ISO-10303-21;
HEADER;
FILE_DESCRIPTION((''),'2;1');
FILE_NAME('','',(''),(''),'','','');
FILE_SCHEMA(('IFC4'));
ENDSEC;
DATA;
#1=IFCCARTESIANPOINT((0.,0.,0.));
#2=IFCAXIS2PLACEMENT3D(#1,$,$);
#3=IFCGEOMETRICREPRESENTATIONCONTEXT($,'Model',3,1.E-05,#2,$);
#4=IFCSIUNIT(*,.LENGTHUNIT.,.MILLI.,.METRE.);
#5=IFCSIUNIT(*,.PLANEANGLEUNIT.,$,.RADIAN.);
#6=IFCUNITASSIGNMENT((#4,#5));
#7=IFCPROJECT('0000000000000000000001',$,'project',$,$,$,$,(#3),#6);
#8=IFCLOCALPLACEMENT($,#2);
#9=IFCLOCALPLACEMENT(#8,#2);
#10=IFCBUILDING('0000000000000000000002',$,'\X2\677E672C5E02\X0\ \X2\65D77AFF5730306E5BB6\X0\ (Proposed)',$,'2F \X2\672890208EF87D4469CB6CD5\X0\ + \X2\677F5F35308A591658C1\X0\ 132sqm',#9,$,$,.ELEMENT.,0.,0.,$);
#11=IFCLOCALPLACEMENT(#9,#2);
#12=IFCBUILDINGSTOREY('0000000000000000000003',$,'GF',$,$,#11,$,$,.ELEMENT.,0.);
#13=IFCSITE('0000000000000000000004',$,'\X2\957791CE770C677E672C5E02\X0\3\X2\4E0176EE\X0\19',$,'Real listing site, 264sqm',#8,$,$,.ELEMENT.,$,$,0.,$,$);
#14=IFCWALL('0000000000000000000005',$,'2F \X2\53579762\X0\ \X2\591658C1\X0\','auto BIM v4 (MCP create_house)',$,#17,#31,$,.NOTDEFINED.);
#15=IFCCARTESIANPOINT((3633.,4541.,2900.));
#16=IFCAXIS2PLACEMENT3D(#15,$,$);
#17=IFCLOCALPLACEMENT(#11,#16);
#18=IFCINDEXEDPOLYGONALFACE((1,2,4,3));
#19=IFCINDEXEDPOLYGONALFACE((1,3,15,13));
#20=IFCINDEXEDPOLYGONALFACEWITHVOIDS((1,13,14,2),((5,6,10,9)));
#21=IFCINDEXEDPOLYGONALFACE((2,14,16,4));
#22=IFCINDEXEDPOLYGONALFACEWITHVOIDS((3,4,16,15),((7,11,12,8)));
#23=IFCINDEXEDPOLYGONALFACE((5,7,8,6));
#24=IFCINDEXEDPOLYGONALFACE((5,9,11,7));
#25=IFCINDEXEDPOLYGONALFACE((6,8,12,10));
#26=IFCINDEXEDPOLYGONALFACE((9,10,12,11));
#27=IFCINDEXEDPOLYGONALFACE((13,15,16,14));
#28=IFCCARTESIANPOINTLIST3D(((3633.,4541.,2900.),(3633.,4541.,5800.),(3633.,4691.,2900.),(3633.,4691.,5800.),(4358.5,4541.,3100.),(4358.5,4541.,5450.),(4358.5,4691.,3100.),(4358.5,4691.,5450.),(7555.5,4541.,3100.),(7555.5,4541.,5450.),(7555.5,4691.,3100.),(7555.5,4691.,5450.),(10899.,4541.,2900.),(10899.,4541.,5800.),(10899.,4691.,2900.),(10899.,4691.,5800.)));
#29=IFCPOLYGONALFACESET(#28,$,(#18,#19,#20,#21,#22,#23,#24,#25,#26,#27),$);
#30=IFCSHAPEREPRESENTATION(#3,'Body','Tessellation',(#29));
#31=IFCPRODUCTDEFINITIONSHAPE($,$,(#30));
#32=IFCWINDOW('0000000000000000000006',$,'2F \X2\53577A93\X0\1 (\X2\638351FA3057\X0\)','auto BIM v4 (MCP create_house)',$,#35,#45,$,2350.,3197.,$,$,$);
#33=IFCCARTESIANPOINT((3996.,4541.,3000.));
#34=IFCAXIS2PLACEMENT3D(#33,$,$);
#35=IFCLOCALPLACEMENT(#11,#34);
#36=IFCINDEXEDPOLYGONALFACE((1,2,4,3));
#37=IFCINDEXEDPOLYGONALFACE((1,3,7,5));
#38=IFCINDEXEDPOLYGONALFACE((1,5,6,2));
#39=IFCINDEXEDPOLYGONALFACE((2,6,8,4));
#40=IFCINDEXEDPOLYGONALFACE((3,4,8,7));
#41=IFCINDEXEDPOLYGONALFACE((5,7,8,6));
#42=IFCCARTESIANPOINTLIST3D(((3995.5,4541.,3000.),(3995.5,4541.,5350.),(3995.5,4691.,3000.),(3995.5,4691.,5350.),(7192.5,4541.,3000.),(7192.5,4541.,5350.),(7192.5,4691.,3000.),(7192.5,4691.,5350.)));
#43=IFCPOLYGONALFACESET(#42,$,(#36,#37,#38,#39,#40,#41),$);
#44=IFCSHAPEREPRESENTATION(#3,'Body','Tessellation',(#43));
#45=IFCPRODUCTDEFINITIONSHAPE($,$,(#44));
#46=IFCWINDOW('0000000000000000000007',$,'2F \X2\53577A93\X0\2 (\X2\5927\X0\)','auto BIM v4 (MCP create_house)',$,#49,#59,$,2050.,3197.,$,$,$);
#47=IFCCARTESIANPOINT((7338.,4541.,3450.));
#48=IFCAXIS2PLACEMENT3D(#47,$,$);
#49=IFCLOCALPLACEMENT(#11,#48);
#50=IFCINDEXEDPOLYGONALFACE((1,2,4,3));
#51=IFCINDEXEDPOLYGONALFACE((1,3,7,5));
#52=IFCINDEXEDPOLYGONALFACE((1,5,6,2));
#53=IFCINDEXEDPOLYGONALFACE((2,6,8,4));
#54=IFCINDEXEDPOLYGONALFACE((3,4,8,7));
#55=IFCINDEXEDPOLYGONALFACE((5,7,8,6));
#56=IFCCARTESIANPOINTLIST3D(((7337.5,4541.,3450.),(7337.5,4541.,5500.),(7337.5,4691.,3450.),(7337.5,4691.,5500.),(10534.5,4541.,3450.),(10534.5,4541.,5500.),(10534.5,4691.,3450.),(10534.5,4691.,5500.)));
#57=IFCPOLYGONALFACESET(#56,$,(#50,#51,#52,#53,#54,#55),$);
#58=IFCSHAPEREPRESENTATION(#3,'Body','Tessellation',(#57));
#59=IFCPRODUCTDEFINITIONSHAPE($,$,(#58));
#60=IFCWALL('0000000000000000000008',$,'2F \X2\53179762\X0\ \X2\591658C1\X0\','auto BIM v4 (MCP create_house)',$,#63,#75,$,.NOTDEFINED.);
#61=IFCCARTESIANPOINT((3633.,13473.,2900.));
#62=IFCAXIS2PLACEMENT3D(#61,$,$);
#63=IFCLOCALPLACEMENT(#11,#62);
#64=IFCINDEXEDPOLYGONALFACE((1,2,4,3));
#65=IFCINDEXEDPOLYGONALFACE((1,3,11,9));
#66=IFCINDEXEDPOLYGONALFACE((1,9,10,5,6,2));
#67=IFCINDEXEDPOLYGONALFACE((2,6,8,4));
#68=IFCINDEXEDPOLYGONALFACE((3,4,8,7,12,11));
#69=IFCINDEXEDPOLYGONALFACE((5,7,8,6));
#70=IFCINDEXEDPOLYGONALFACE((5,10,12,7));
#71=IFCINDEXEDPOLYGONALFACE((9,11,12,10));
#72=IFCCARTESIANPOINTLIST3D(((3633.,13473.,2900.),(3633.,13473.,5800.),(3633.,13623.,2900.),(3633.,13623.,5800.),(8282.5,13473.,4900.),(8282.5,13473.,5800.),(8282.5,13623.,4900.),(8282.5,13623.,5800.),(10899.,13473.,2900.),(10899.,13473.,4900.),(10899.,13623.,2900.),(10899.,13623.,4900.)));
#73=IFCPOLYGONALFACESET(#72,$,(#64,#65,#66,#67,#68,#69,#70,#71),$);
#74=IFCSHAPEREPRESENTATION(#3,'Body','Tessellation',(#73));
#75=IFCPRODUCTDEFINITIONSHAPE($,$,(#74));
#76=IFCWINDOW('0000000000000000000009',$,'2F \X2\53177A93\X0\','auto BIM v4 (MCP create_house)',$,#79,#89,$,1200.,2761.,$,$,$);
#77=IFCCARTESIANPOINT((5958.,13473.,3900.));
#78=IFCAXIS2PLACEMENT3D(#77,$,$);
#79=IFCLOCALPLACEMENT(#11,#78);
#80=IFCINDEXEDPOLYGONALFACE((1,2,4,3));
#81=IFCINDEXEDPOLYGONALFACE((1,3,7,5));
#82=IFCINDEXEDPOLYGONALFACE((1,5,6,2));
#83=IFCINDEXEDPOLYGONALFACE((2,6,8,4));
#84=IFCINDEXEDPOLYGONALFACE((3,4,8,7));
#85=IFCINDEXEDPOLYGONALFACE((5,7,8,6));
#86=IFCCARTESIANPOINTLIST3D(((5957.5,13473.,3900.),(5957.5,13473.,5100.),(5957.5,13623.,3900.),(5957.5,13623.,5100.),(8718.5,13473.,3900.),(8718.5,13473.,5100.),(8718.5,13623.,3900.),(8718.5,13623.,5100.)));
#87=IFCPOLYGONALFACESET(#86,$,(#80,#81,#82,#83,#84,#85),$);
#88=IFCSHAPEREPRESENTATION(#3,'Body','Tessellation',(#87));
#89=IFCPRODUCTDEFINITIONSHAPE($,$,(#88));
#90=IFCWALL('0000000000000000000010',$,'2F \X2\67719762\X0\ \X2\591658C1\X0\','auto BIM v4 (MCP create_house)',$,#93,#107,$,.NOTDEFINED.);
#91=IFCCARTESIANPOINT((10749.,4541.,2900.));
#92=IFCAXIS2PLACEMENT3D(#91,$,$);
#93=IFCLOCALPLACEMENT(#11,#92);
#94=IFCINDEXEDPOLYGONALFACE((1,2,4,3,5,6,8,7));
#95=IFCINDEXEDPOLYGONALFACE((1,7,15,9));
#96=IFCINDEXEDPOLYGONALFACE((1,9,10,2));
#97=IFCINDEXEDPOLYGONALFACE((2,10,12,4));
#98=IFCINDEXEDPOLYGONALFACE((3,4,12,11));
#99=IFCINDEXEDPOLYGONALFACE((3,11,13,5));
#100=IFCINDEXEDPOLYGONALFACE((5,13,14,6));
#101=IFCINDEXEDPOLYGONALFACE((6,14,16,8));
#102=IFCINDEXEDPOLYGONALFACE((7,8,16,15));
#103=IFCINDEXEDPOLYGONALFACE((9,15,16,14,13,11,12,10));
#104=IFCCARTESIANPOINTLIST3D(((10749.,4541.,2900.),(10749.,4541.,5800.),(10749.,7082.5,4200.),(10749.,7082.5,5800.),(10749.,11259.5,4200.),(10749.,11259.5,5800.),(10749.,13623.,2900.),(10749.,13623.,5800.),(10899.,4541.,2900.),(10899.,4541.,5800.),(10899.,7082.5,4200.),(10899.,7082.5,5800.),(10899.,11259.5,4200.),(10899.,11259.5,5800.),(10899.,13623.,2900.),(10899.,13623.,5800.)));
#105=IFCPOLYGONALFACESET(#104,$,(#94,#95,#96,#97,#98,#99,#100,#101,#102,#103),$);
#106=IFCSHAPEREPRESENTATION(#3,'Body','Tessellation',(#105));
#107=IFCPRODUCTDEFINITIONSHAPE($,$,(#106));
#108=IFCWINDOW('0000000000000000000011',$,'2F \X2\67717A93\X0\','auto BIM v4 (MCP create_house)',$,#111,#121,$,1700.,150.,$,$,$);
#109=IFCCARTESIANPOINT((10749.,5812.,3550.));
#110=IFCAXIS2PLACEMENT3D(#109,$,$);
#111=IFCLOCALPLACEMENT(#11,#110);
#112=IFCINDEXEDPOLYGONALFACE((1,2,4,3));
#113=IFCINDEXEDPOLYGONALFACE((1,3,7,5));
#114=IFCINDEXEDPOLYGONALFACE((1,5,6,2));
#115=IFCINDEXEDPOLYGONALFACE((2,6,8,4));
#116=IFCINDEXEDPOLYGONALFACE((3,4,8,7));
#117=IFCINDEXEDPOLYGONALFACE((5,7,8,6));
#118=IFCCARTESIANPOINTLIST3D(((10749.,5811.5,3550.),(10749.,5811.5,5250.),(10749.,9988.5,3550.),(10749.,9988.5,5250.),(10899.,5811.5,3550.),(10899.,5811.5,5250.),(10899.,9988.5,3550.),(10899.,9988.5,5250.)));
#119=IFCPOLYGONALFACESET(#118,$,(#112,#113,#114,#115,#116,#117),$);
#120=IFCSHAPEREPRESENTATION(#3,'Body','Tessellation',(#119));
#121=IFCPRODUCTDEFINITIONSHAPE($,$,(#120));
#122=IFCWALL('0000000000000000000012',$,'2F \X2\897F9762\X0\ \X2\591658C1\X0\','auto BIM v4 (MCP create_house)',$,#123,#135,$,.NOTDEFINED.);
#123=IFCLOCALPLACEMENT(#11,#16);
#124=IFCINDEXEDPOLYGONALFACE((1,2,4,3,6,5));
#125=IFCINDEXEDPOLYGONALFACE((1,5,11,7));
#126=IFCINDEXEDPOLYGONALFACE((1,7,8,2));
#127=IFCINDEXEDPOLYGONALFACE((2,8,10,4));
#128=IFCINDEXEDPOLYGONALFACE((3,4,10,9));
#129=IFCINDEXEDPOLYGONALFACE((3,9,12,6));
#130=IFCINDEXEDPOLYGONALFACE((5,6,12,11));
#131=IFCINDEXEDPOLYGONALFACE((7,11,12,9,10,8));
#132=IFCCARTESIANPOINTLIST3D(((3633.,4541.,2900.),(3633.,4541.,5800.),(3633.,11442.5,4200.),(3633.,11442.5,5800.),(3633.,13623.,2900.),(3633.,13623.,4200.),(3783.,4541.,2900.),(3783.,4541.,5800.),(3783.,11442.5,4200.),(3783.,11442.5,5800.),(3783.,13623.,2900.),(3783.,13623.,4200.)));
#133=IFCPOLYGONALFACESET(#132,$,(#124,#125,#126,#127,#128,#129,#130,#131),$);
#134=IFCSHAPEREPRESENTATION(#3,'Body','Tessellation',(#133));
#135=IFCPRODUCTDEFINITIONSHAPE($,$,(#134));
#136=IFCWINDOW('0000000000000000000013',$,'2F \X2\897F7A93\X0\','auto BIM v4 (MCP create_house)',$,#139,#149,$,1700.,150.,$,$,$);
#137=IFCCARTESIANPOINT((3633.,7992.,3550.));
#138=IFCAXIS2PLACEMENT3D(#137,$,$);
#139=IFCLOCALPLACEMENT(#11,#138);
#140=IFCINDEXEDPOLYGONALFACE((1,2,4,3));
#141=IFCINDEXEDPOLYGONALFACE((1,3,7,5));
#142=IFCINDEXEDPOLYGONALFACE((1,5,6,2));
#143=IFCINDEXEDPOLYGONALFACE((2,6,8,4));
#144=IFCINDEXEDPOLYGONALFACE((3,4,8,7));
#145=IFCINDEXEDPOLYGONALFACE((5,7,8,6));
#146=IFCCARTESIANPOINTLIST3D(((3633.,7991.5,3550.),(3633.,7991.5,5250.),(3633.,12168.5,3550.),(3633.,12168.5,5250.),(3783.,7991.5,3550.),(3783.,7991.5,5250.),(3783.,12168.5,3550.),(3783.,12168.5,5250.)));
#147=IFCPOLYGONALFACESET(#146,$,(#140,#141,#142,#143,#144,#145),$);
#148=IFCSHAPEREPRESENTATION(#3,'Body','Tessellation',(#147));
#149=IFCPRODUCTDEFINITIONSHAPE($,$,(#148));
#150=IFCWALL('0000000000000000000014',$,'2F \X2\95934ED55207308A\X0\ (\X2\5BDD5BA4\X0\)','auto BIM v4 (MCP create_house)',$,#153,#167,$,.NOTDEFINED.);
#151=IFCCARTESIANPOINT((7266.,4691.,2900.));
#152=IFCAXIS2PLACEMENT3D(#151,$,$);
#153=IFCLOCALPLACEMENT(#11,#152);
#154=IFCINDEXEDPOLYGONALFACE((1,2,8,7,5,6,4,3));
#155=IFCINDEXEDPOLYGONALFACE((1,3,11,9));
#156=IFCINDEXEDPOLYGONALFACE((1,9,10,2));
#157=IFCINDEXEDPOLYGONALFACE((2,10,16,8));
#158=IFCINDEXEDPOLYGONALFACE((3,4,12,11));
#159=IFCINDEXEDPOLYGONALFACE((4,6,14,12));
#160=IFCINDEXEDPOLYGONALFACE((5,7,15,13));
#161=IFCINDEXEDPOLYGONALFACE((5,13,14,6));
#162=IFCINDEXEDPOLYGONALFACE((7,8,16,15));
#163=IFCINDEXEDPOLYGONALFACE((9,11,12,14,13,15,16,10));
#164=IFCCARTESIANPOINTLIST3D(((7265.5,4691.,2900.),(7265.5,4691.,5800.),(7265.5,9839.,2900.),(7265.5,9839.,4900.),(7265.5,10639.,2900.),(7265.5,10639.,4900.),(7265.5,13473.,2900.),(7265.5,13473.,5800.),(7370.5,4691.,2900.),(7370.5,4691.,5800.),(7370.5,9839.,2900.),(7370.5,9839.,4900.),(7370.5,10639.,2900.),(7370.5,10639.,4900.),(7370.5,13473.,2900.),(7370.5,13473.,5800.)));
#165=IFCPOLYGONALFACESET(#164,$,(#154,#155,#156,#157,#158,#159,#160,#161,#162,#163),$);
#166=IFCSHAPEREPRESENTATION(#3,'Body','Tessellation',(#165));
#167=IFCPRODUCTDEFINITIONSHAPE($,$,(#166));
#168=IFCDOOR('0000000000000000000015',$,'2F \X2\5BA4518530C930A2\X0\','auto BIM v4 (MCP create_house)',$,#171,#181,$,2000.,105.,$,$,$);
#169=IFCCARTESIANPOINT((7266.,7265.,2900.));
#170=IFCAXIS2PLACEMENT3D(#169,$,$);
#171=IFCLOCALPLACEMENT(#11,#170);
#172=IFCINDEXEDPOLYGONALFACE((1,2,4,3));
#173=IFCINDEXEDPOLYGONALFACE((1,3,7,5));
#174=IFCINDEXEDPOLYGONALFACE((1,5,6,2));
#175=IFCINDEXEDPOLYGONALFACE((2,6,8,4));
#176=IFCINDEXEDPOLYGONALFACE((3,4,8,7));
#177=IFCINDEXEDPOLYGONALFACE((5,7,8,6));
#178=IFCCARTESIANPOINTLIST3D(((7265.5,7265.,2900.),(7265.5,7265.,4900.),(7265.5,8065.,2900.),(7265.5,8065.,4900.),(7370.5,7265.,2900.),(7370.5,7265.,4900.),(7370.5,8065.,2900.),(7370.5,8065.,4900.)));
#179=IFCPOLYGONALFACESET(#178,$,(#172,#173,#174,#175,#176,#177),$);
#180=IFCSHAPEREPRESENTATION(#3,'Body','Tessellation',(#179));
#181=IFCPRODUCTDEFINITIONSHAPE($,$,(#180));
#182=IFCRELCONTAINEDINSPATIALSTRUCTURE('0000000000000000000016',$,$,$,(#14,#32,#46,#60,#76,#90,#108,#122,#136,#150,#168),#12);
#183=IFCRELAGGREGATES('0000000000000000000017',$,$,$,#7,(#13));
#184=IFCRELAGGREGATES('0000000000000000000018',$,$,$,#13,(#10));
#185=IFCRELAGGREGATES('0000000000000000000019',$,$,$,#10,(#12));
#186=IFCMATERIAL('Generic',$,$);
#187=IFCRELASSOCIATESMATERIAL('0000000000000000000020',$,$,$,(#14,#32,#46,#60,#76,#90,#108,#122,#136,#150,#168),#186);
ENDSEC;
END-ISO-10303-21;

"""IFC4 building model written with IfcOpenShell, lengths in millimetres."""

from ifc_helpers import new_model, si_unit, frame, frame_2d, origin, place, context, project, spatial, rectangle, extrude, material, element, fill, save


model = new_model("IFC4")

# Units and contexts
model_context = context("Model", 3, precision=1e-05, world=origin())
ifc_project = project(units=[si_unit("LENGTHUNIT", "METRE", prefix="MILLI"), si_unit("PLANEANGLEUNIT", "RADIAN")], contexts=[model_context])

# Site, building, storey
site_placement = place(None, origin())
site = spatial("IfcSite", under=ifc_project, at=site_placement, Name="長野県松本市3丁目19", ObjectType="Real listing site, 264sqm", CompositionType="ELEMENT", RefElevation=0.0)
building_placement = place(site_placement, origin())
building = spatial("IfcBuilding", under=site, at=building_placement, Name="松本市 旗竿地の家 (Proposed)", ObjectType="2F 木造軸組構法 + 板張り外壁 132sqm", CompositionType="ELEMENT", ElevationOfRefHeight=0.0, ElevationOfTerrain=0.0)
storey_placement = place(building_placement, origin())
storey = spatial("IfcBuildingStorey", under=building, at=storey_placement, Name="GF", CompositionType="ELEMENT", Elevation=0.0)

# Shared definitions
ifc_material = material(Name="Generic")

# Wall, openings, windows
wall_1_placement = place(storey_placement, frame((3633.0, 4541.0, 2900.0)))
wall_1 = element("IfcWall", 1, at=wall_1_placement, inside=storey, material=ifc_material, Name="2F 南面 外壁", Description="auto BIM v4 (MCP create_house)", PredefinedType="NOTDEFINED", context=model_context, shape_type="SweptSolid", body=[
    extrude(rectangle(XDim=7266.0, YDim=150.0, at=frame_2d((3633.0, 75.0))), frame((3633.0, 4541.0, 2900.0)), (0.0, 0.0, 1.0), 2900.0),
])
opening_1_placement = place(storey_placement, frame((3996.0, 4541.0, 3000.0)))
opening_1 = element("IfcOpeningElement", 2, at=opening_1_placement, cuts=wall_1, PredefinedType="NOTDEFINED", context=model_context, shape_type="SweptSolid", body=[
    extrude(rectangle(XDim=3197.0, YDim=150.0, at=frame_2d((1598.0, 75.0))), frame((3996.0, 4541.0, 3000.0)), (0.0, 0.0, 1.0), 2350.0),
])
opening_2_placement = place(storey_placement, frame((7338.0, 4541.0, 3450.0)))
opening_2 = element("IfcOpeningElement", 3, at=opening_2_placement, cuts=wall_1, PredefinedType="NOTDEFINED", context=model_context, shape_type="SweptSolid", body=[
    extrude(rectangle(XDim=3197.0, YDim=150.0, at=frame_2d((1598.0, 75.0))), frame((7338.0, 4541.0, 3450.0)), (0.0, 0.0, 1.0), 2050.0),
])
window_1_placement = place(storey_placement, frame((3996.0, 4541.0, 3000.0)))
window_1 = element("IfcWindow", 4, at=window_1_placement, inside=storey, material=ifc_material, Name="2F 南窓1 (掃出し)", Description="auto BIM v4 (MCP create_house)", OverallHeight=2350.0, OverallWidth=3197.0, context=model_context, shape_type="SweptSolid", body=[
    extrude(rectangle(XDim=3197.0, YDim=150.0, at=frame_2d((1598.0, 75.0))), frame((3996.0, 4541.0, 3000.0)), (0.0, 0.0, 1.0), 2350.0),
])
fill(opening_1, window_1)
window_2_placement = place(storey_placement, frame((7338.0, 4541.0, 3450.0)))
window_2 = element("IfcWindow", 5, at=window_2_placement, inside=storey, material=ifc_material, Name="2F 南窓2 (大)", Description="auto BIM v4 (MCP create_house)", OverallHeight=2050.0, OverallWidth=3197.0, context=model_context, shape_type="SweptSolid", body=[
    extrude(rectangle(XDim=3197.0, YDim=150.0, at=frame_2d((1598.0, 75.0))), frame((7338.0, 4541.0, 3450.0)), (0.0, 0.0, 1.0), 2050.0),
])
fill(opening_2, window_2)

# Walls, openings, windows
wall_2_placement = place(storey_placement, frame((3633.0, 13473.0, 2900.0)))
wall_2 = element("IfcWall", 6, at=wall_2_placement, inside=storey, material=ifc_material, Name="2F 北面 外壁", Description="auto BIM v4 (MCP create_house)", PredefinedType="NOTDEFINED", context=model_context, shape_type="SweptSolid", body=[
    extrude(rectangle(XDim=7266.0, YDim=150.0, at=frame_2d((3633.0, 75.0))), frame((3633.0, 13473.0, 2900.0)), (0.0, 0.0, 1.0), 2900.0),
])
opening_3_placement = place(storey_placement, frame((5958.0, 13473.0, 3900.0)))
opening_3 = element("IfcOpeningElement", 7, at=opening_3_placement, cuts=wall_2, PredefinedType="NOTDEFINED", context=model_context, shape_type="SweptSolid", body=[
    extrude(rectangle(XDim=2761.0, YDim=150.0, at=frame_2d((1380.0, 75.0))), frame((5958.0, 13473.0, 3900.0)), (0.0, 0.0, 1.0), 1200.0),
])
window_3_placement = place(storey_placement, frame((5958.0, 13473.0, 3900.0)))
window_3 = element("IfcWindow", 8, at=window_3_placement, inside=storey, material=ifc_material, Name="2F 北窓", Description="auto BIM v4 (MCP create_house)", OverallHeight=1200.0, OverallWidth=2761.0, context=model_context, shape_type="SweptSolid", body=[
    extrude(rectangle(XDim=2761.0, YDim=150.0, at=frame_2d((1380.0, 75.0))), frame((5958.0, 13473.0, 3900.0)), (0.0, 0.0, 1.0), 1200.0),
])
fill(opening_3, window_3)
wall_3_placement = place(storey_placement, frame((10749.0, 4541.0, 2900.0)))
wall_3 = element("IfcWall", 9, at=wall_3_placement, inside=storey, material=ifc_material, Name="2F 東面 外壁", Description="auto BIM v4 (MCP create_house)", PredefinedType="NOTDEFINED", context=model_context, shape_type="SweptSolid", body=[
    extrude(rectangle(XDim=150.0, YDim=9082.0, at=frame_2d((75.0, 4541.0))), frame((10749.0, 4541.0, 2900.0)), (0.0, 0.0, 1.0), 2900.0),
])
opening_4_placement = place(storey_placement, frame((10749.0, 5812.0, 3550.0)))
opening_4 = element("IfcOpeningElement", 10, at=opening_4_placement, cuts=wall_3, PredefinedType="NOTDEFINED", context=model_context, shape_type="SweptSolid", body=[
    extrude(rectangle(XDim=150.0, YDim=4177.0, at=frame_2d((75.0, 2088.0))), frame((10749.0, 5812.0, 3550.0)), (0.0, 0.0, 1.0), 1700.0),
])
window_4_placement = place(storey_placement, frame((10749.0, 5812.0, 3550.0)))
window_4 = element("IfcWindow", 11, at=window_4_placement, inside=storey, material=ifc_material, Name="2F 東窓", Description="auto BIM v4 (MCP create_house)", OverallHeight=1700.0, OverallWidth=150.0, context=model_context, shape_type="SweptSolid", body=[
    extrude(rectangle(XDim=150.0, YDim=4177.0, at=frame_2d((75.0, 2088.0))), frame((10749.0, 5812.0, 3550.0)), (0.0, 0.0, 1.0), 1700.0),
])
fill(opening_4, window_4)
wall_4_placement = place(storey_placement, frame((3633.0, 4541.0, 2900.0)))
wall_4 = element("IfcWall", 12, at=wall_4_placement, inside=storey, material=ifc_material, Name="2F 西面 外壁", Description="auto BIM v4 (MCP create_house)", PredefinedType="NOTDEFINED", context=model_context, shape_type="SweptSolid", body=[
    extrude(rectangle(XDim=150.0, YDim=9082.0, at=frame_2d((75.0, 4541.0))), frame((3633.0, 4541.0, 2900.0)), (0.0, 0.0, 1.0), 2900.0),
])
opening_5_placement = place(storey_placement, frame((3633.0, 7992.0, 3550.0)))
opening_5 = element("IfcOpeningElement", 13, at=opening_5_placement, cuts=wall_4, PredefinedType="NOTDEFINED", context=model_context, shape_type="SweptSolid", body=[
    extrude(rectangle(XDim=150.0, YDim=4177.0, at=frame_2d((75.0, 2088.0))), frame((3633.0, 7992.0, 3550.0)), (0.0, 0.0, 1.0), 1700.0),
])
window_5_placement = place(storey_placement, frame((3633.0, 7992.0, 3550.0)))
window_5 = element("IfcWindow", 14, at=window_5_placement, inside=storey, material=ifc_material, Name="2F 西窓", Description="auto BIM v4 (MCP create_house)", OverallHeight=1700.0, OverallWidth=150.0, context=model_context, shape_type="SweptSolid", body=[
    extrude(rectangle(XDim=150.0, YDim=4177.0, at=frame_2d((75.0, 2088.0))), frame((3633.0, 7992.0, 3550.0)), (0.0, 0.0, 1.0), 1700.0),
])
fill(opening_5, window_5)

# Wall, opening, door
wall_5_placement = place(storey_placement, frame((7266.0, 4691.0, 2900.0)))
wall_5 = element("IfcWall", 15, at=wall_5_placement, inside=storey, material=ifc_material, Name="2F 間仕切り (寝室)", Description="auto BIM v4 (MCP create_house)", PredefinedType="NOTDEFINED", context=model_context, shape_type="SweptSolid", body=[
    extrude(rectangle(XDim=105.0, YDim=8782.0, at=frame_2d((52.0, 4391.0))), frame((7266.0, 4691.0, 2900.0)), (0.0, 0.0, 1.0), 2900.0),
])
opening_6_placement = place(storey_placement, frame((7266.0, 7265.0, 2900.0)))
opening_6 = element("IfcOpeningElement", 16, at=opening_6_placement, cuts=wall_5, PredefinedType="NOTDEFINED", context=model_context, shape_type="SweptSolid", body=[
    extrude(rectangle(XDim=105.0, YDim=800.0, at=frame_2d((52.0, 400.0))), frame((7266.0, 7265.0, 2900.0)), (0.0, 0.0, 1.0), 2000.0),
])
door_1_placement = place(storey_placement, frame((7266.0, 7265.0, 2900.0)))
door_1 = element("IfcDoor", 17, at=door_1_placement, inside=storey, material=ifc_material, Name="2F 室内ドア", Description="auto BIM v4 (MCP create_house)", OverallHeight=2000.0, OverallWidth=105.0, context=model_context, shape_type="SweptSolid", body=[
    extrude(rectangle(XDim=105.0, YDim=800.0, at=frame_2d((52.0, 400.0))), frame((7266.0, 7265.0, 2900.0)), (0.0, 0.0, 1.0), 2000.0),
])
fill(opening_6, door_1)

save(model, "model.ifc")
